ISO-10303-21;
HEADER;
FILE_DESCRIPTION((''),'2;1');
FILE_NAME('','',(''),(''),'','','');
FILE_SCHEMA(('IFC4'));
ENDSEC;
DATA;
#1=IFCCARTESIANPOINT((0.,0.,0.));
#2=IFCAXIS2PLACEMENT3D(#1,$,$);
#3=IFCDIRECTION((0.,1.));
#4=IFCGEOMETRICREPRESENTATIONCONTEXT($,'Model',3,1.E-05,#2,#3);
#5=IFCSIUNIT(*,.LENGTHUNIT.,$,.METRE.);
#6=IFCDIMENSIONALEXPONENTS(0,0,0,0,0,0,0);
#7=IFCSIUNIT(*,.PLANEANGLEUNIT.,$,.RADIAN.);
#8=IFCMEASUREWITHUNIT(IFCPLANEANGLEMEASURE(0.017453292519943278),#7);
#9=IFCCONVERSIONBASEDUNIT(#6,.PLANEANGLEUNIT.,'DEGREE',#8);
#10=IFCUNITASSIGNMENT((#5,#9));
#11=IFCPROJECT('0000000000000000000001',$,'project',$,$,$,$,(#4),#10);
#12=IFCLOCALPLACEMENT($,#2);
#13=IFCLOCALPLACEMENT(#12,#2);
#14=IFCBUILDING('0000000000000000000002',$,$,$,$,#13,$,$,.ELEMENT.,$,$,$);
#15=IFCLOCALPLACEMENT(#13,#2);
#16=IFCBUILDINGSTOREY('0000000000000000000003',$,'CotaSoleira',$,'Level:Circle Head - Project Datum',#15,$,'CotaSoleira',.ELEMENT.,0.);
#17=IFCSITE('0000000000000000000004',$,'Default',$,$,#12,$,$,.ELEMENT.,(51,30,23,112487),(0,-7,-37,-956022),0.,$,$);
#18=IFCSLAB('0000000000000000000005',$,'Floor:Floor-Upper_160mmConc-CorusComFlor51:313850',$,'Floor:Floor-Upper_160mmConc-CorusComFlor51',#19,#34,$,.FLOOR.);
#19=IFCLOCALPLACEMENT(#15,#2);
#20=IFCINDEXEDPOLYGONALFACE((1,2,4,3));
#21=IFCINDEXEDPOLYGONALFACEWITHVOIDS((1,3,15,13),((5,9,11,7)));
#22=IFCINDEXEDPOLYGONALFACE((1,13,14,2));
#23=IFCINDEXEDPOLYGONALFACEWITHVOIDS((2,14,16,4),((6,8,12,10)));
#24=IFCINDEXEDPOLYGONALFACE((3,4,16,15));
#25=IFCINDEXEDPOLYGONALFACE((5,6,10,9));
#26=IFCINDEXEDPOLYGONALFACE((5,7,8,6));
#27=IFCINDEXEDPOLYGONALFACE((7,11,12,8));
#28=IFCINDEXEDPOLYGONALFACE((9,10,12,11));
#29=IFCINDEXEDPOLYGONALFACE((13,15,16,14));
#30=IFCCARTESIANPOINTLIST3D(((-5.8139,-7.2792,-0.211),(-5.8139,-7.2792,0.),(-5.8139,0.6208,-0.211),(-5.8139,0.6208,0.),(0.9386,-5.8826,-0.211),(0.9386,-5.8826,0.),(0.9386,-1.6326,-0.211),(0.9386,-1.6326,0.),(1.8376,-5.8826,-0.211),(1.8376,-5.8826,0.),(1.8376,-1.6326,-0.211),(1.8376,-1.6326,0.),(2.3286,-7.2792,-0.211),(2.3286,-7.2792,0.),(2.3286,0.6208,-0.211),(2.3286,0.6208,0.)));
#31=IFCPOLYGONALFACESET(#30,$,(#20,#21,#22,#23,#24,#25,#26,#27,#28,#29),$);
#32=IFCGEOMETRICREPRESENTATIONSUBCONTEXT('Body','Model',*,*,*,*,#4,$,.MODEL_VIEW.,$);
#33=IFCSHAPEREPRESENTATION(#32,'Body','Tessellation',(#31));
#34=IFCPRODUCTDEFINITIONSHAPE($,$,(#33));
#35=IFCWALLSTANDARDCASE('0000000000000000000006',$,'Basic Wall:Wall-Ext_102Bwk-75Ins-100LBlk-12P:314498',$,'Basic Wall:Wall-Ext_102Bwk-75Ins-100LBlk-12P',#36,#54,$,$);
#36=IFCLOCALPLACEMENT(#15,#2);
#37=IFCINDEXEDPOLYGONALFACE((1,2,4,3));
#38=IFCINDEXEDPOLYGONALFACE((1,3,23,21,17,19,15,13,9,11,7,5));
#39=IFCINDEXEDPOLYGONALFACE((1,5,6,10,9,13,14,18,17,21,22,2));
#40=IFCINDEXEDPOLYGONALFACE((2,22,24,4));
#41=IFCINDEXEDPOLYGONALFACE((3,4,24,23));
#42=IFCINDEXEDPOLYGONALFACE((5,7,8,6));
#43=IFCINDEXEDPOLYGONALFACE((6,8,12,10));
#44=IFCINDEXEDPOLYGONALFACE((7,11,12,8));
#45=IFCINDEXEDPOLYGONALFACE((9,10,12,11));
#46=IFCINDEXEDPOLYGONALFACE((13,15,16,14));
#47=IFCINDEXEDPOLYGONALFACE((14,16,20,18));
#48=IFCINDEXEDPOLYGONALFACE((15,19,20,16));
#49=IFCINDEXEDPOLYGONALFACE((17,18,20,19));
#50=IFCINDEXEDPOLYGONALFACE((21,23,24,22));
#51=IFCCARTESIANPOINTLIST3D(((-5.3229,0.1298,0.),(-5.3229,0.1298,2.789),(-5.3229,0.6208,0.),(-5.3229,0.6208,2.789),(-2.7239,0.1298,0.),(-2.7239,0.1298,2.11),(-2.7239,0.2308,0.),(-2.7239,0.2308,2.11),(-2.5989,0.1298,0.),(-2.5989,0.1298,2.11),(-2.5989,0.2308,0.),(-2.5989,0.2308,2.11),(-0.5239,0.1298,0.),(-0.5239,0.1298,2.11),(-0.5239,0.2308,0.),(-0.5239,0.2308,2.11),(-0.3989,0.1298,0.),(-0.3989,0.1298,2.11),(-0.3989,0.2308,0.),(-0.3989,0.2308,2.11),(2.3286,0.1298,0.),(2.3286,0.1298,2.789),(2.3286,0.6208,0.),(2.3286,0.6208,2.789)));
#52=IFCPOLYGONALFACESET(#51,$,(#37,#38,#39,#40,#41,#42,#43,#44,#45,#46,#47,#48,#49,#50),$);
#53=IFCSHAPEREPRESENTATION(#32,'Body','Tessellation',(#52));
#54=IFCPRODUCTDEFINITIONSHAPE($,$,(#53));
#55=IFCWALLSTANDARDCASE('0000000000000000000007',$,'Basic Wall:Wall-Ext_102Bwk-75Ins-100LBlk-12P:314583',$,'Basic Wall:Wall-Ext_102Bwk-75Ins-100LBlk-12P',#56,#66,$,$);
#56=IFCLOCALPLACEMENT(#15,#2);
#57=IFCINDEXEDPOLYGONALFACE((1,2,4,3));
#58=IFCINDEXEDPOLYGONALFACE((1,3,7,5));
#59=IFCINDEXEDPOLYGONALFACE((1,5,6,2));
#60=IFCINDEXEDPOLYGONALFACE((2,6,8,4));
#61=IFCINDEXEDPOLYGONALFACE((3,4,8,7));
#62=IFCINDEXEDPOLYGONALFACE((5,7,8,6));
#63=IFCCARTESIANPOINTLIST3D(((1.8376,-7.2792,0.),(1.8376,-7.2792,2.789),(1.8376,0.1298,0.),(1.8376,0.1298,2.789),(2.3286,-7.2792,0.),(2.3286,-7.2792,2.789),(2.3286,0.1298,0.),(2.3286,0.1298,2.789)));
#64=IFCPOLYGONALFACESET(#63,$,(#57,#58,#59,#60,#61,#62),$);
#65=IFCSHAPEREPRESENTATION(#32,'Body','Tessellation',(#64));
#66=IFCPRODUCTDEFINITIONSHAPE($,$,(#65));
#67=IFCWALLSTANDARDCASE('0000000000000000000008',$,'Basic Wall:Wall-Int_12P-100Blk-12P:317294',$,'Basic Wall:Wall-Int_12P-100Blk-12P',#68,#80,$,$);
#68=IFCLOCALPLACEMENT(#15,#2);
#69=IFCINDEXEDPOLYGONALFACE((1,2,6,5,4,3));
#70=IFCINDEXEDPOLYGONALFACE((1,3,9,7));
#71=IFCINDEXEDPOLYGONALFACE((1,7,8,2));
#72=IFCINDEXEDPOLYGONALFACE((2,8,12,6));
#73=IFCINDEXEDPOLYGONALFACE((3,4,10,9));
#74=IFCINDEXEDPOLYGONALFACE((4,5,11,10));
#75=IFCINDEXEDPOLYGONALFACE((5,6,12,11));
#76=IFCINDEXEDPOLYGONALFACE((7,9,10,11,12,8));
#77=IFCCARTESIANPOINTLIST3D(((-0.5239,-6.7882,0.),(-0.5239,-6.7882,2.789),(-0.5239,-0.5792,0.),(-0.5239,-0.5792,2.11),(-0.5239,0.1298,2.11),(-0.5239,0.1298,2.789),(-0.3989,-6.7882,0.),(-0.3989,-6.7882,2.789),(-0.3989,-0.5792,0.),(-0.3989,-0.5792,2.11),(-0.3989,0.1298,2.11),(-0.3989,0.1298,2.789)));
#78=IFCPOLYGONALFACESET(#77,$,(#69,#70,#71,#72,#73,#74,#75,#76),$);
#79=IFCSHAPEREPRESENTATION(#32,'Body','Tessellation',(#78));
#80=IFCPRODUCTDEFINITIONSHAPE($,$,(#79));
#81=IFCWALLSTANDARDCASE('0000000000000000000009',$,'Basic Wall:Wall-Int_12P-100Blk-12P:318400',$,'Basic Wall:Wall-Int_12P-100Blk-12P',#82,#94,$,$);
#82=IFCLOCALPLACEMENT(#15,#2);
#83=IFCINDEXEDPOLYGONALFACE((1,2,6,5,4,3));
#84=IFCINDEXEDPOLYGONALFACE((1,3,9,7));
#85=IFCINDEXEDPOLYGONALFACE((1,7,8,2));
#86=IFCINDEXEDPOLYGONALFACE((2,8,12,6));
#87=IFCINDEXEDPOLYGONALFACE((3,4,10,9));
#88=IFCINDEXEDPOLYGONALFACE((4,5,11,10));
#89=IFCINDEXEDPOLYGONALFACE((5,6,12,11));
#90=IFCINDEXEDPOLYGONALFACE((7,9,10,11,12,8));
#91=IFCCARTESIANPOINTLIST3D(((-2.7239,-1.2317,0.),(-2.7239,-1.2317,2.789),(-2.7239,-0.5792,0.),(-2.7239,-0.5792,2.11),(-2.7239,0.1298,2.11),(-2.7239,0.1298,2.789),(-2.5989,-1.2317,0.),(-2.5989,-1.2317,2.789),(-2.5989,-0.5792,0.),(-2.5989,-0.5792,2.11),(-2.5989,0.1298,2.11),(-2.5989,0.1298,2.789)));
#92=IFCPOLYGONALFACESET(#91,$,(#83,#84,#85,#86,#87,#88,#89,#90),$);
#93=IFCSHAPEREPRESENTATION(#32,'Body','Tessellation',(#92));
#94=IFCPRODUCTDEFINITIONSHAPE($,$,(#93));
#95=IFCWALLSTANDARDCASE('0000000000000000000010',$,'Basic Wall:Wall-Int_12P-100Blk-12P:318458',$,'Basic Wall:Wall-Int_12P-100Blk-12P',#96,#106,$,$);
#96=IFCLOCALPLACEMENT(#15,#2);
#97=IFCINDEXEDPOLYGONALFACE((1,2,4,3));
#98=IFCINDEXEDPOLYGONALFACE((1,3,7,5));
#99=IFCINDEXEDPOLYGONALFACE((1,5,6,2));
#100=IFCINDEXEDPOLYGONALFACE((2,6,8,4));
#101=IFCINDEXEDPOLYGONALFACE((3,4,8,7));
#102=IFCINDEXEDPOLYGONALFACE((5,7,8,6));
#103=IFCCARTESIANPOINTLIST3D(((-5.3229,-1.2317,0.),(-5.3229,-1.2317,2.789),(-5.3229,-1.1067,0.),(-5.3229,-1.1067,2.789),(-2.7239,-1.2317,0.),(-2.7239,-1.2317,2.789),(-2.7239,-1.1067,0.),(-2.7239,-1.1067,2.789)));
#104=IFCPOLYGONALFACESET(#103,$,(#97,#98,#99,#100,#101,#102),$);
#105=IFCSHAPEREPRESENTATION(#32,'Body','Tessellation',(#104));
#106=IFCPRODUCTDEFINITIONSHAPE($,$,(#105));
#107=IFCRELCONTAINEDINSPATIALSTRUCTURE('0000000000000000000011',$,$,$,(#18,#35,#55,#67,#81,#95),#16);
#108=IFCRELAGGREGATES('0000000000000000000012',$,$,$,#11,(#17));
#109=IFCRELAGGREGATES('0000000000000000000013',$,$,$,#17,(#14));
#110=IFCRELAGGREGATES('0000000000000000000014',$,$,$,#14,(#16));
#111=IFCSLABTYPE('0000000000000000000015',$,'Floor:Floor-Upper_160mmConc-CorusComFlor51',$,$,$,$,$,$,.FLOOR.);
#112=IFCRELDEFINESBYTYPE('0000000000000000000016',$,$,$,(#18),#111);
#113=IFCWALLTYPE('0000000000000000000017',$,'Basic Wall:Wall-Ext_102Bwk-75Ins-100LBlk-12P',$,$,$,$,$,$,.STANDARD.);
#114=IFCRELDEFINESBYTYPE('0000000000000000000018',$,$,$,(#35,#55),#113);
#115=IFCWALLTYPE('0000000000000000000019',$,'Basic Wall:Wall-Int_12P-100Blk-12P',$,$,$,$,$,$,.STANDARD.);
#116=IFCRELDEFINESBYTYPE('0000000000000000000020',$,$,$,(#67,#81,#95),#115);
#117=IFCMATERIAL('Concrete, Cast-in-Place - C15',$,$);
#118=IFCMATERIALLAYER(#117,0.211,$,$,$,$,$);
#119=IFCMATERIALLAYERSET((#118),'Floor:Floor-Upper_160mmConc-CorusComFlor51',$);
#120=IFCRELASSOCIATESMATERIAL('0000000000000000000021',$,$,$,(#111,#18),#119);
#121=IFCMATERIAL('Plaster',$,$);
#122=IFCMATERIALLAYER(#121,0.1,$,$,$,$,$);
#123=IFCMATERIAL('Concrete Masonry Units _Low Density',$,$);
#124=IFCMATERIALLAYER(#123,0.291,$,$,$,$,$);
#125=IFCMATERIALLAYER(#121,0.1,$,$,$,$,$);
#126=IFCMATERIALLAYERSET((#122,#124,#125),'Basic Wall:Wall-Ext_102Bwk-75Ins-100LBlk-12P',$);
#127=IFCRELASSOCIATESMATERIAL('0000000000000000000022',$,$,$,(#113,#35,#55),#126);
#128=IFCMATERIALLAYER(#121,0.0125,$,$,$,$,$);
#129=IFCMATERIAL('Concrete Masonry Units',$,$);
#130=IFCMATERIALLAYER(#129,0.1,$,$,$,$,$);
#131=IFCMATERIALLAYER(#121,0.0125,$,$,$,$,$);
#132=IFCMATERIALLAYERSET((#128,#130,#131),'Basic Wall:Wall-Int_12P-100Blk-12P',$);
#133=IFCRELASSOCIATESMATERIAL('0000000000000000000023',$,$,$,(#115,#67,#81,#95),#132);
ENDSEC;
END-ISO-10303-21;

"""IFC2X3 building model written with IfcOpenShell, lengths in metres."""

from ifc_helpers import new_model, entity, si_unit, converted_unit, direction, frame, frame_2d, origin, origin_2d_with_axis, place, context, subcontext, project, spatial, polyline, rectangle, extrude, clip, bounded_halfspace, material, layer, layer_set, layer_usage, type_object, element, save


model = new_model("IFC2X3")

# Units and contexts
model_context = context("Model", 3, precision=1e-05, world=origin(), true_north=direction((0.0, 1.0)))
body_context = subcontext(model_context, "Body", "Model", "MODEL_VIEW")
ifc_project = project(units=[si_unit("LENGTHUNIT", "METRE"), converted_unit("PLANEANGLEUNIT", "DEGREE", entity("IfcPlaneAngleMeasure", 0.017453292519943278), si_unit("PLANEANGLEUNIT", "RADIAN"), dimensions=[0, 0, 0, 0, 0, 0, 0])], contexts=[model_context])

# Site, building, storey
site_placement = place(None, origin())
site = spatial("IfcSite", under=ifc_project, at=site_placement, Name="Default", CompositionType="ELEMENT", RefLatitude=(51, 30, 23, 112487), RefLongitude=(0, -7, -37, -956022), RefElevation=0.0)
building_placement = place(site_placement, origin())
building = spatial("IfcBuilding", under=site, at=building_placement, CompositionType="ELEMENT")
storey_placement = place(building_placement, origin())
storey = spatial("IfcBuildingStorey", under=building, at=storey_placement, Name="CotaSoleira", ObjectType="Level:Circle Head - Project Datum", LongName="CotaSoleira", CompositionType="ELEMENT", Elevation=0.0)

# Slab, opening
ifc_material_1 = material(Name="Concrete, Cast-in-Place - C15")
ifc_layer_1 = layer(ifc_material_1, 0.211)
ifc_layer_set_1 = layer_set([ifc_layer_1], Name="Floor:Floor-Upper_160mmConc-CorusComFlor51")
ifc_layer_usage_1 = layer_usage(ifc_layer_set_1, "AXIS3", "POSITIVE", 0.0)
slab_type = type_object("IfcSlabType", Name="Floor:Floor-Upper_160mmConc-CorusComFlor51", PredefinedType="FLOOR", material=ifc_layer_set_1)
slab_placement = place(storey_placement, origin())
slab = element("IfcSlab", 1, at=slab_placement, inside=storey, type_object=slab_type, material=ifc_layer_usage_1, Name="Floor:Floor-Upper_160mmConc-CorusComFlor51:313850", ObjectType="Floor:Floor-Upper_160mmConc-CorusComFlor51", PredefinedType="FLOOR", context=body_context, shape_type="SweptSolid", body=[
    extrude(rectangle(XDim=8.1425, YDim=7.9, at=origin_2d_with_axis()), frame((-1.7426, -3.3292, 0.0), z_axis=(0.0, 0.0, -1.0), x_axis=(-1.0, 0.0, 0.0)), (0.0, 0.0, 1.0), 0.211),
])
opening_1_placement = place(slab_placement, origin())
element("IfcOpeningElement", 2, at=opening_1_placement, cuts=slab, ObjectType="Opening", context=body_context, shape_type="SweptSolid", body=[
    extrude(rectangle(XDim=4.25, YDim=0.899, at=frame_2d((0.0, 0.0), x_axis=(1.0, 0.0))), frame((1.3881, -3.7576, 0.0), z_axis=(0.0, 0.0, -1.0), x_axis=(0.0, -1.0, 0.0)), (0.0, 0.0, 1.0), 0.211),
])

# Wall, openings
ifc_material_2 = material(Name="Plaster")
ifc_layer_2 = layer(ifc_material_2, 0.1)
ifc_material_3 = material(Name="Concrete Masonry Units _Low Density")
ifc_layer_3 = layer(ifc_material_3, 0.291)
ifc_layer_4 = layer(ifc_material_2, 0.1)
ifc_layer_set_2 = layer_set([ifc_layer_2, ifc_layer_3, ifc_layer_4], Name="Basic Wall:Wall-Ext_102Bwk-75Ins-100LBlk-12P")
ifc_layer_usage_2 = layer_usage(ifc_layer_set_2, "AXIS2", "NEGATIVE", 0.2455)
wall_type_1 = type_object("IfcWallType", Name="Basic Wall:Wall-Ext_102Bwk-75Ins-100LBlk-12P", PredefinedType="STANDARD", material=ifc_layer_set_2)
wall_1_placement = place(storey_placement, frame((-5.3229, 0.3753, 0.0)))
wall_1 = element("IfcWallStandardCase", 3, at=wall_1_placement, inside=storey, type_object=wall_type_1, material=ifc_layer_usage_2, Name="Basic Wall:Wall-Ext_102Bwk-75Ins-100LBlk-12P:314498", ObjectType="Basic Wall:Wall-Ext_102Bwk-75Ins-100LBlk-12P", context=body_context, shape_type="Clipping", body=[
    clip(extrude(rectangle(XDim=7.6515, YDim=0.491, at=frame_2d((3.8258, 0.0), x_axis=(-1.0, 0.0))), origin(), (0.0, 0.0, 1.0), 2.789), bounded_halfspace(frame((0.0, -0.2455, 2.789), z_axis=(0.0, 0.0, -1.0), x_axis=(0.0, -1.0, 0.0)), True, frame((0.0, -0.2455, 2.789)), polyline([(0.0, 0.0), (2.599, 0.0), (2.724, 0.0), (4.799, 0.0), (4.924, 0.0), (7.1605, 0.0), (7.6515, 0.0), (7.6515, 0.491), (0.0, 0.491), (0.0, 0.0)]))),
])
opening_2_placement = place(wall_1_placement, origin())
element("IfcOpeningElement", 4, at=opening_2_placement, cuts=wall_1, ObjectType="Opening", context=body_context, shape_type="SweptSolid", body=[
    extrude(rectangle(XDim=2.11, YDim=0.125, at=frame_2d((0.0, 0.0), x_axis=(0.0, 1.0))), frame((2.6615, -0.9545, 1.055), z_axis=(0.0, 1.0, 0.0), x_axis=(-1.0, 0.0, 0.0)), (0.0, 0.0, 1.0), 0.81),
])
opening_3_placement = place(wall_1_placement, origin())
element("IfcOpeningElement", 5, at=opening_3_placement, cuts=wall_1, ObjectType="Opening", context=body_context, shape_type="SweptSolid", body=[
    extrude(rectangle(XDim=2.11, YDim=0.125, at=frame_2d((0.0, 0.0), x_axis=(0.0, 1.0))), frame((4.8615, -0.9545, 1.055), z_axis=(0.0, 1.0, 0.0), x_axis=(-1.0, 0.0, 0.0)), (0.0, 0.0, 1.0), 0.81),
])

# Wall
wall_2_placement = place(storey_placement, frame((2.0831, 0.1298, 0.0), z_axis=(0.0, 0.0, 1.0), x_axis=(0.0, -1.0, 0.0)))
element("IfcWallStandardCase", 6, at=wall_2_placement, inside=storey, type_object=wall_type_1, material=ifc_layer_usage_2, Name="Basic Wall:Wall-Ext_102Bwk-75Ins-100LBlk-12P:314583", ObjectType="Basic Wall:Wall-Ext_102Bwk-75Ins-100LBlk-12P", context=body_context, shape_type="Clipping", body=[
    clip(extrude(rectangle(XDim=7.409, YDim=0.491, at=frame_2d((3.7045, 0.0), x_axis=(-1.0, 0.0))), origin(), (0.0, 0.0, 1.0), 2.789), bounded_halfspace(frame((0.0, -0.2455, 2.789), z_axis=(0.0, 0.0, -1.0), x_axis=(1.0, 0.0, 0.0)), True, frame((0.0, -0.2455, 2.789)), polyline([(0.0, 0.0), (1.7625, 0.0), (6.0125, 0.0), (6.918, 0.0), (7.409, 0.0), (7.409, 0.491), (0.0, 0.491), (0.0, 0.0)]))),
])

# Walls, openings
ifc_layer_5 = layer(ifc_material_2, 0.0125)
ifc_material_4 = material(Name="Concrete Masonry Units")
ifc_layer_6 = layer(ifc_material_4, 0.1)
ifc_layer_7 = layer(ifc_material_2, 0.0125)
ifc_layer_set_3 = layer_set([ifc_layer_5, ifc_layer_6, ifc_layer_7], Name="Basic Wall:Wall-Int_12P-100Blk-12P")
ifc_layer_usage_3 = layer_usage(ifc_layer_set_3, "AXIS2", "NEGATIVE", 0.0625)
wall_type_2 = type_object("IfcWallType", Name="Basic Wall:Wall-Int_12P-100Blk-12P", PredefinedType="STANDARD", material=ifc_layer_set_3)
wall_3_placement = place(storey_placement, frame((-0.4614, 0.1298, 0.0), z_axis=(0.0, 0.0, 1.0), x_axis=(0.0, -1.0, 0.0)))
wall_3 = element("IfcWallStandardCase", 7, at=wall_3_placement, inside=storey, type_object=wall_type_2, material=ifc_layer_usage_3, Name="Basic Wall:Wall-Int_12P-100Blk-12P:317294", ObjectType="Basic Wall:Wall-Int_12P-100Blk-12P", context=body_context, shape_type="Clipping", body=[
    clip(extrude(rectangle(XDim=6.918, YDim=0.125, at=frame_2d((3.459, 0.0), x_axis=(-1.0, 0.0))), origin(), (0.0, 0.0, 1.0), 2.789), bounded_halfspace(frame((0.0, -0.0625, 2.789), z_axis=(0.0, 0.0, -1.0), x_axis=(1.0, 0.0, 0.0)), True, frame((0.0, -0.0625, 2.789)), polyline([(0.0, 0.0), (6.918, 0.0), (6.918, 0.125), (0.0, 0.125), (0.0, 0.0)]))),
])
opening_4_placement = place(wall_3_placement, frame((0.709, 0.0625, 0.0)))
element("IfcOpeningElement", 8, at=opening_4_placement, cuts=wall_3, ObjectType="Opening", context=body_context, shape_type="SweptSolid", body=[
    extrude(rectangle(XDim=2.11, YDim=0.81, at=frame_2d((1.055, 0.405), x_axis=(1.0, 0.0))), frame((0.0, 0.0, 0.0), z_axis=(0.0, -1.0, 0.0), x_axis=(0.0, 0.0, 1.0)), (0.0, 0.0, 1.0), 0.125),
])
wall_4_placement = place(storey_placement, frame((-2.6614, 0.1298, 0.0), z_axis=(0.0, 0.0, 1.0), x_axis=(0.0, -1.0, 0.0)))
wall_4 = element("IfcWallStandardCase", 9, at=wall_4_placement, inside=storey, type_object=wall_type_2, material=ifc_layer_usage_3, Name="Basic Wall:Wall-Int_12P-100Blk-12P:318400", ObjectType="Basic Wall:Wall-Int_12P-100Blk-12P", context=body_context, shape_type="Clipping", body=[
    clip(extrude(rectangle(XDim=1.3615, YDim=0.125, at=frame_2d((0.6808, 0.0), x_axis=(-1.0, 0.0))), origin(), (0.0, 0.0, 1.0), 2.789), bounded_halfspace(frame((0.0, -0.0625, 2.789), z_axis=(0.0, 0.0, -1.0), x_axis=(1.0, 0.0, 0.0)), True, frame((0.0, -0.0625, 2.789)), polyline([(0.0, 0.0), (1.2365, 0.0), (1.3615, 0.0), (1.3615, 0.125), (0.0, 0.125), (0.0, 0.0)]))),
])
opening_5_placement = place(wall_4_placement, frame((0.709, 0.0625, 0.0)))
element("IfcOpeningElement", 10, at=opening_5_placement, cuts=wall_4, ObjectType="Opening", context=body_context, shape_type="SweptSolid", body=[
    extrude(rectangle(XDim=2.11, YDim=0.81, at=frame_2d((1.055, 0.405), x_axis=(1.0, 0.0))), frame((0.0, 0.0, 0.0), z_axis=(0.0, -1.0, 0.0), x_axis=(0.0, 0.0, 1.0)), (0.0, 0.0, 1.0), 0.125),
])

# Wall
wall_5_placement = place(storey_placement, frame((-2.7239, -1.1692, 0.0), z_axis=(0.0, 0.0, 1.0), x_axis=(-1.0, 0.0, 0.0)))
element("IfcWallStandardCase", 11, at=wall_5_placement, inside=storey, type_object=wall_type_2, material=ifc_layer_usage_3, Name="Basic Wall:Wall-Int_12P-100Blk-12P:318458", ObjectType="Basic Wall:Wall-Int_12P-100Blk-12P", context=body_context, shape_type="Clipping", body=[
    clip(extrude(rectangle(XDim=2.599, YDim=0.125, at=frame_2d((1.2995, 0.0), x_axis=(-1.0, 0.0))), origin(), (0.0, 0.0, 1.0), 2.789), bounded_halfspace(frame((0.0, -0.0625, 2.789), z_axis=(0.0, 0.0, -1.0), x_axis=(0.0, 1.0, 0.0)), True, frame((0.0, -0.0625, 2.789)), polyline([(0.0, 0.0), (2.599, 0.0), (2.599, 0.125), (0.0, 0.125), (0.0, 0.0)]))),
])

save(model, "model.ifc")
